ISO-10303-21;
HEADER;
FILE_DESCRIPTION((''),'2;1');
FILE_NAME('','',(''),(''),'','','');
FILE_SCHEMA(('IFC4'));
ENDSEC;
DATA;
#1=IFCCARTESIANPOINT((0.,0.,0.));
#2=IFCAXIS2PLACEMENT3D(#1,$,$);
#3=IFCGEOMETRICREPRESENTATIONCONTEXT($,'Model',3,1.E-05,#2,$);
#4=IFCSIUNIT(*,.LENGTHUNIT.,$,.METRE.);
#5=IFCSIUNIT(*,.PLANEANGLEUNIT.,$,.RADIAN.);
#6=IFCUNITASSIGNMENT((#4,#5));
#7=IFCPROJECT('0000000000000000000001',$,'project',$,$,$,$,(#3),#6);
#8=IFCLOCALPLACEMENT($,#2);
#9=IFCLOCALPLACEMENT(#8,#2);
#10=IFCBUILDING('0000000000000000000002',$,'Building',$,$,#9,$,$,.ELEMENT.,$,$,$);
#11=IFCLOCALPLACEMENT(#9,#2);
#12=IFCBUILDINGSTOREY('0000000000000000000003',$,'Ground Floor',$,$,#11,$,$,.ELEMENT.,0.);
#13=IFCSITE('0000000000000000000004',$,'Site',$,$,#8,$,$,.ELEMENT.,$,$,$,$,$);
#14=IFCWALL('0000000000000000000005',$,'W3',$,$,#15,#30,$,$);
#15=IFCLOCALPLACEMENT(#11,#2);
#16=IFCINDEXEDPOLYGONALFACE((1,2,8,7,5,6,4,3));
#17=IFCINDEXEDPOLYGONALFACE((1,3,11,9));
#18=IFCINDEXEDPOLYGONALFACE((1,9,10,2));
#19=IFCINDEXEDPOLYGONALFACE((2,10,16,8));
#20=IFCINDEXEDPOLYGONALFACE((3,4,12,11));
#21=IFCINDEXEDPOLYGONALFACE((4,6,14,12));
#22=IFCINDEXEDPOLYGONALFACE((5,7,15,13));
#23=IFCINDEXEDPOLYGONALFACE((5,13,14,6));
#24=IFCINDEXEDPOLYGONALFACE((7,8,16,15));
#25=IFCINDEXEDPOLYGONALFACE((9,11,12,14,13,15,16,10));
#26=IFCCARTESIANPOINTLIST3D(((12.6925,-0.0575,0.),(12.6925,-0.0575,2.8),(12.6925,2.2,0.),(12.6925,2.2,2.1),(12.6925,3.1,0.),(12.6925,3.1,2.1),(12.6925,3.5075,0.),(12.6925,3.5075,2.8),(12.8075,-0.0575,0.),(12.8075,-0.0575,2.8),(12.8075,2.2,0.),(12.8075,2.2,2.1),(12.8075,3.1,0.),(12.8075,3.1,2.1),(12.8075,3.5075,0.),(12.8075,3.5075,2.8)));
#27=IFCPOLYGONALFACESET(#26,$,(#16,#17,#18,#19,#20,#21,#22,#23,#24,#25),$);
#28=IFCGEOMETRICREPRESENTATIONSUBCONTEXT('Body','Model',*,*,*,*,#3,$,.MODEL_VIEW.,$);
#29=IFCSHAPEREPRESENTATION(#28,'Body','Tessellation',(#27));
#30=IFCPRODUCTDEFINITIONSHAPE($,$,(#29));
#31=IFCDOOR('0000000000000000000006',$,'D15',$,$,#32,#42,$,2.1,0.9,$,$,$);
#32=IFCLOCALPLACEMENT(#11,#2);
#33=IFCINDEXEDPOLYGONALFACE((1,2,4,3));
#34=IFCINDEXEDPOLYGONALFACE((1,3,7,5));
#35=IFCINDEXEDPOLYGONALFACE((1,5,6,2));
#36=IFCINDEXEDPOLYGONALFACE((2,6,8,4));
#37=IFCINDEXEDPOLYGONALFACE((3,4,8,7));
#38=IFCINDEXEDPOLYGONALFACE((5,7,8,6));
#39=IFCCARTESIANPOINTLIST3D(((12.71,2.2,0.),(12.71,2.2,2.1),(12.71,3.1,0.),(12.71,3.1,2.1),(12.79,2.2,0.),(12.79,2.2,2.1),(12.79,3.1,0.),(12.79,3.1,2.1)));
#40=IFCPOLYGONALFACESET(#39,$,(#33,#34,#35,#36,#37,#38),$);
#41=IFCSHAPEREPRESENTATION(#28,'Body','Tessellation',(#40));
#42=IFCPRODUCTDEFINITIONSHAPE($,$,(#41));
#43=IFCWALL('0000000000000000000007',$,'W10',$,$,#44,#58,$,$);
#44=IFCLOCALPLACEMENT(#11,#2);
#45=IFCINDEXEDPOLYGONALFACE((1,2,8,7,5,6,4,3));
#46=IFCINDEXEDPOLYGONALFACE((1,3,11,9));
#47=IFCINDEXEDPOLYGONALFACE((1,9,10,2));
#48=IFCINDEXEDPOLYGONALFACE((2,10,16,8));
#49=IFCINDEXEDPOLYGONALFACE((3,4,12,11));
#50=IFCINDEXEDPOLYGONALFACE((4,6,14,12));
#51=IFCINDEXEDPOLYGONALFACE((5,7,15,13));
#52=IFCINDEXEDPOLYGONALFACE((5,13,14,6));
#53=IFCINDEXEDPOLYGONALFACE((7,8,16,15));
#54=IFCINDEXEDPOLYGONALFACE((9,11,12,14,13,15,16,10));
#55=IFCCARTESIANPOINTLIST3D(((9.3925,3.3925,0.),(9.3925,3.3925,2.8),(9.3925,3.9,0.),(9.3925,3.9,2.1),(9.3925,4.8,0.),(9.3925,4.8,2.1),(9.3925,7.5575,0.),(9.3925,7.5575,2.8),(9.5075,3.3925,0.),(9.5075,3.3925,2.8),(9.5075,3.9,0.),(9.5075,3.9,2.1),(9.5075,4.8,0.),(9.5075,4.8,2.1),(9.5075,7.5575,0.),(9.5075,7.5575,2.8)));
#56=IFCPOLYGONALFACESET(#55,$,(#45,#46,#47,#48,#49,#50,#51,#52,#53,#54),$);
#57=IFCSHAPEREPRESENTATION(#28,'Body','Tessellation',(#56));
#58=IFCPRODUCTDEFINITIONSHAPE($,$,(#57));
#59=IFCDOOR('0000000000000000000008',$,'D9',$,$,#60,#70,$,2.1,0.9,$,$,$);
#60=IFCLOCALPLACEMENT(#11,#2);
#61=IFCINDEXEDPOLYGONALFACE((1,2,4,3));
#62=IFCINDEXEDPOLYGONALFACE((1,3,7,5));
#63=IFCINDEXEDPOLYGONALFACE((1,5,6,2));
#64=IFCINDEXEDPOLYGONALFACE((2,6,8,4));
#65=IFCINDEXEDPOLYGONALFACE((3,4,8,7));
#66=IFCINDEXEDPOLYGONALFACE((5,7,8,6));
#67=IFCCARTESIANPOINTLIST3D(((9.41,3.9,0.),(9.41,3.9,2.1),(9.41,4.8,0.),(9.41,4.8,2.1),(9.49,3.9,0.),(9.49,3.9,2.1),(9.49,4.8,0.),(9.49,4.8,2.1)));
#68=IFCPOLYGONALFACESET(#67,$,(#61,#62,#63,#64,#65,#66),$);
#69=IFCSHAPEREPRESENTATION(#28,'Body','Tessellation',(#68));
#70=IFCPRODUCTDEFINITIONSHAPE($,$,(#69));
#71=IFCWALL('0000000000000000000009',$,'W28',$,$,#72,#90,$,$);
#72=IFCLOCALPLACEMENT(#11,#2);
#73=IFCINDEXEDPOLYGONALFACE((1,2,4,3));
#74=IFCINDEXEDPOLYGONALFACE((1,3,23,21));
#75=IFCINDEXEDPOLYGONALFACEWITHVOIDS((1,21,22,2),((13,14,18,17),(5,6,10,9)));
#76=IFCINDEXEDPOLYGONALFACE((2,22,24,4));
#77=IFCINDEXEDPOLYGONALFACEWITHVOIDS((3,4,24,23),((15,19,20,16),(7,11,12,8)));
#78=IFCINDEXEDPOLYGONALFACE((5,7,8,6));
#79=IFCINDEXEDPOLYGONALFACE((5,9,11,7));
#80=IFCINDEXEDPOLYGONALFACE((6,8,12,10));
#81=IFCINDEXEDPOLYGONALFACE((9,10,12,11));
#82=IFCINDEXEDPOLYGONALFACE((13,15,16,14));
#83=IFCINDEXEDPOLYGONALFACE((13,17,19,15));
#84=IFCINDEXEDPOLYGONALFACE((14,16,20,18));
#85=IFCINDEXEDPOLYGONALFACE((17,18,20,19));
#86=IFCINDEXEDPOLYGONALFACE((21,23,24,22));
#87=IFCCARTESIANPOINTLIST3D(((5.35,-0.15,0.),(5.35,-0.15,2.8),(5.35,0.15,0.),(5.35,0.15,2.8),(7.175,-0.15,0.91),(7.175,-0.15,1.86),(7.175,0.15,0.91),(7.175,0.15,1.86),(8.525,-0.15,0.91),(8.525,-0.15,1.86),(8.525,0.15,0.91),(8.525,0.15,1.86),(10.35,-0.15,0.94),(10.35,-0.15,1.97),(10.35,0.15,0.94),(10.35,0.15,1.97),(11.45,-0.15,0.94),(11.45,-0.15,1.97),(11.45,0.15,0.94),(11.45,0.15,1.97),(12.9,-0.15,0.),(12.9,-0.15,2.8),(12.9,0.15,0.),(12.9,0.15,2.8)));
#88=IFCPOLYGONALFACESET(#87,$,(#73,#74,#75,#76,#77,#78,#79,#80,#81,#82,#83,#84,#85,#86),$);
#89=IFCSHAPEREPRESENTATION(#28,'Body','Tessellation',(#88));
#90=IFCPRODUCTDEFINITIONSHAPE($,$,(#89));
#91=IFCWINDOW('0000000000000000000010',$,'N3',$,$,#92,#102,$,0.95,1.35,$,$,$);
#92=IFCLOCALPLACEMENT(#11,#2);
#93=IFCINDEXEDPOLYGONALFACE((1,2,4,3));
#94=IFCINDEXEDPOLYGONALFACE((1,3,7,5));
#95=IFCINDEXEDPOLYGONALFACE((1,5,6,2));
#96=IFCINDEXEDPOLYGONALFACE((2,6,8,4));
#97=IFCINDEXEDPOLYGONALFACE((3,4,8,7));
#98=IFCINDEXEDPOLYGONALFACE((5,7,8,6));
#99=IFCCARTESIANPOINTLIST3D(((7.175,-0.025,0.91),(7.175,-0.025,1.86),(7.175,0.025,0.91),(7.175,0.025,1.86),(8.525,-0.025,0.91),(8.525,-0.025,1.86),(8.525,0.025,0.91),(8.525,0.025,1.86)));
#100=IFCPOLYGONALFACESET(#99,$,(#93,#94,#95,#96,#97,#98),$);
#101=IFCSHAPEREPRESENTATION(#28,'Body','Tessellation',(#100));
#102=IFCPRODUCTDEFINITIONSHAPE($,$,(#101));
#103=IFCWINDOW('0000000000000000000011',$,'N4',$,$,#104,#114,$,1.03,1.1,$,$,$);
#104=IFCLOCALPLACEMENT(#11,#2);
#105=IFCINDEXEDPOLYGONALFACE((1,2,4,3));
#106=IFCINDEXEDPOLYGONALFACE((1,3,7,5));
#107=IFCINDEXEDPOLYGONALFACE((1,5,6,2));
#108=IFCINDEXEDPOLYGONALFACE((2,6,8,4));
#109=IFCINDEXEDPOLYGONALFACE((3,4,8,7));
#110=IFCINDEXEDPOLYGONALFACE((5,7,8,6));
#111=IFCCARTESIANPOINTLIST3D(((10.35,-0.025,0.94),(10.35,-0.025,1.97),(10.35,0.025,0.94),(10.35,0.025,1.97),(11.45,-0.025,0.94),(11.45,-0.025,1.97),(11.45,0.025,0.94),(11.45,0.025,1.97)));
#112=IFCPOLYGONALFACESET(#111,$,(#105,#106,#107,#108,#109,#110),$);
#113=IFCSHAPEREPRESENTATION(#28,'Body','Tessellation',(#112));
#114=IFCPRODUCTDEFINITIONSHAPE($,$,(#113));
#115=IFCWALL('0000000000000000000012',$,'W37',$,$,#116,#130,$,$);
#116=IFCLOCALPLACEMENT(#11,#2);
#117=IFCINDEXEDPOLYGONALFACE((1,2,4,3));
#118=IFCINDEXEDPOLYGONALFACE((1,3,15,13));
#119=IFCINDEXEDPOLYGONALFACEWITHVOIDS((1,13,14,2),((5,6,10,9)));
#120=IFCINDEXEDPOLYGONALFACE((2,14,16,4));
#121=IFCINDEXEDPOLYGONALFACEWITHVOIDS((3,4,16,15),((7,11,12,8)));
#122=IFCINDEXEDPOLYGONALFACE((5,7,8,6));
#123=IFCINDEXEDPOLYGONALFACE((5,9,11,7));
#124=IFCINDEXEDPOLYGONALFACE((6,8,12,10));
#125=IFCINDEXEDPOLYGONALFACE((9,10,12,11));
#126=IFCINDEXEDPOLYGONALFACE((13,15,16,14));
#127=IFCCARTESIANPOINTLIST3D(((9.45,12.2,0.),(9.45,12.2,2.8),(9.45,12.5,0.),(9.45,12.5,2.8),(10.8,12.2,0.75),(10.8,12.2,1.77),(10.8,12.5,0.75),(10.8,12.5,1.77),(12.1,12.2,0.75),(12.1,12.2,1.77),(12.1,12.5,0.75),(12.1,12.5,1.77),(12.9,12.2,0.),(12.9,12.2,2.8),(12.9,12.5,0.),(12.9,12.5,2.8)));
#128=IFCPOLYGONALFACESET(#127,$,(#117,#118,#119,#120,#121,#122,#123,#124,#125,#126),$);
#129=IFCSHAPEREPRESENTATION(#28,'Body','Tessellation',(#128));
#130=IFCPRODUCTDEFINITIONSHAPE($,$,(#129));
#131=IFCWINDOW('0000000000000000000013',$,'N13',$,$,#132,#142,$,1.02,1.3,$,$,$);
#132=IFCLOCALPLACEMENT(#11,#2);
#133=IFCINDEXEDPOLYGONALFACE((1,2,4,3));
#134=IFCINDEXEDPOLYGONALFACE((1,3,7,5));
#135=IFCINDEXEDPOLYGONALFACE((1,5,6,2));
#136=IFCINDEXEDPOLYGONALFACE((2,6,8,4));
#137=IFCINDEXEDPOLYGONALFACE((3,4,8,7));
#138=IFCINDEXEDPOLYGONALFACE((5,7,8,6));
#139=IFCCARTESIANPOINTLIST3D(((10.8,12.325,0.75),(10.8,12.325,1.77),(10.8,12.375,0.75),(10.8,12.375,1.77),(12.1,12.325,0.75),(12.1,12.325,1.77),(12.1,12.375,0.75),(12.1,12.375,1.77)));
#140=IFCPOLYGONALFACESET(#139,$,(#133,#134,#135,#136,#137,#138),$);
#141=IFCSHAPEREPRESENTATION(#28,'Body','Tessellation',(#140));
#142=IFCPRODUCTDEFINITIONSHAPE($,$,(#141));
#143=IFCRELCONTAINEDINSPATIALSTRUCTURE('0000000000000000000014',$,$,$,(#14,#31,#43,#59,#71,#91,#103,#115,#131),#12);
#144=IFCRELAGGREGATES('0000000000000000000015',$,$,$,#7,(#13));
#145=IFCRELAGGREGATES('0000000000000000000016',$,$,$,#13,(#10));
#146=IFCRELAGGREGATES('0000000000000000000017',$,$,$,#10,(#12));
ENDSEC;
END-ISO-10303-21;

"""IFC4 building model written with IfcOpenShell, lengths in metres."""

from ifc_helpers import new_model, si_unit, frame, frame_2d, origin, origin_2d, place, context, subcontext, project, spatial, rectangle, extrude, element, fill, save


model = new_model("IFC4")

# Units and contexts
model_context = context("Model", 3, precision=1e-05, world=origin())
body_context = subcontext(model_context, "Body", "Model", "MODEL_VIEW")
ifc_project = project(units=[si_unit("LENGTHUNIT", "METRE"), si_unit("PLANEANGLEUNIT", "RADIAN")], contexts=[model_context])

# Site, building, storey
site_placement = place(None, origin())
site = spatial("IfcSite", under=ifc_project, at=site_placement, Name="Site", CompositionType="ELEMENT")
building_placement = place(site_placement, origin())
building = spatial("IfcBuilding", under=site, at=building_placement, Name="Building", CompositionType="ELEMENT")
storey_placement = place(building_placement, origin())
storey = spatial("IfcBuildingStorey", under=building, at=storey_placement, Name="Ground Floor", CompositionType="ELEMENT", Elevation=0.0)

# Walls, openings, doors
wall_1_placement = place(storey_placement, frame((12.75, 0.0, 0.0), x_axis=(0.0, 1.0, 0.0)))
wall_1 = element("IfcWall", 1, at=wall_1_placement, inside=storey, Name="W3", context=body_context, shape_type="SweptSolid", body=[
    extrude(rectangle(XDim=3.565, YDim=0.115, at=frame_2d((1.725, 0.0))), origin(), (0.0, 0.0, 1.0), 2.8),
])
opening_1_placement = place(wall_1_placement, frame((2.65, 0.0, 0.0)))
opening_1 = element("IfcOpeningElement", 2, at=opening_1_placement, cuts=wall_1, context=body_context, shape_type="SweptSolid", body=[
    extrude(rectangle(XDim=0.9, YDim=0.215, at=origin_2d()), origin(), (0.0, 0.0, 1.0), 2.1),
])
door_1_placement = place(opening_1_placement, origin())
door_1 = element("IfcDoor", 3, at=door_1_placement, inside=storey, Name="D15", OverallHeight=2.1, OverallWidth=0.9, context=body_context, shape_type="SweptSolid", body=[
    extrude(rectangle(XDim=0.9, YDim=0.08, at=origin_2d()), origin(), (0.0, 0.0, 1.0), 2.1),
])
fill(opening_1, door_1)
wall_2_placement = place(storey_placement, frame((9.45, 3.45, 0.0), x_axis=(0.0, 1.0, 0.0)))
wall_2 = element("IfcWall", 4, at=wall_2_placement, inside=storey, Name="W10", context=body_context, shape_type="SweptSolid", body=[
    extrude(rectangle(XDim=4.165, YDim=0.115, at=frame_2d((2.025, 0.0))), origin(), (0.0, 0.0, 1.0), 2.8),
])
opening_2_placement = place(wall_2_placement, frame((0.9, 0.0, 0.0)))
opening_2 = element("IfcOpeningElement", 5, at=opening_2_placement, cuts=wall_2, context=body_context, shape_type="SweptSolid", body=[
    extrude(rectangle(XDim=0.9, YDim=0.215, at=origin_2d()), origin(), (0.0, 0.0, 1.0), 2.1),
])
door_2_placement = place(opening_2_placement, origin())
door_2 = element("IfcDoor", 6, at=door_2_placement, inside=storey, Name="D9", OverallHeight=2.1, OverallWidth=0.9, context=body_context, shape_type="SweptSolid", body=[
    extrude(rectangle(XDim=0.9, YDim=0.08, at=origin_2d()), origin(), (0.0, 0.0, 1.0), 2.1),
])
fill(opening_2, door_2)

# Wall, openings, windows
wall_3_placement = place(storey_placement, frame((5.5, 0.0, 0.0), x_axis=(1.0, 0.0, 0.0)))
wall_3 = element("IfcWall", 7, at=wall_3_placement, inside=storey, Name="W28", context=body_context, shape_type="SweptSolid", body=[
    extrude(rectangle(XDim=7.55, YDim=0.3, at=frame_2d((3.625, 0.0))), origin(), (0.0, 0.0, 1.0), 2.8),
])
opening_3_placement = place(wall_3_placement, frame((2.35, 0.0, 0.91)))
opening_3 = element("IfcOpeningElement", 8, at=opening_3_placement, cuts=wall_3, context=body_context, shape_type="SweptSolid", body=[
    extrude(rectangle(XDim=1.35, YDim=0.4, at=origin_2d()), origin(), (0.0, 0.0, 1.0), 0.95),
])
opening_4_placement = place(wall_3_placement, frame((5.4, 0.0, 0.94)))
opening_4 = element("IfcOpeningElement", 9, at=opening_4_placement, cuts=wall_3, context=body_context, shape_type="SweptSolid", body=[
    extrude(rectangle(XDim=1.1, YDim=0.4, at=origin_2d()), origin(), (0.0, 0.0, 1.0), 1.03),
])
window_1_placement = place(opening_3_placement, origin())
window_1 = element("IfcWindow", 10, at=window_1_placement, inside=storey, Name="N3", OverallHeight=0.95, OverallWidth=1.35, context=body_context, shape_type="SweptSolid", body=[
    extrude(rectangle(XDim=1.35, YDim=0.05, at=origin_2d()), origin(), (0.0, 0.0, 1.0), 0.95),
])
fill(opening_3, window_1)
window_2_placement = place(opening_4_placement, origin())
window_2 = element("IfcWindow", 11, at=window_2_placement, inside=storey, Name="N4", OverallHeight=1.03, OverallWidth=1.1, context=body_context, shape_type="SweptSolid", body=[
    extrude(rectangle(XDim=1.1, YDim=0.05, at=origin_2d()), origin(), (0.0, 0.0, 1.0), 1.03),
])
fill(opening_4, window_2)

# Wall, opening, window
wall_4_placement = place(storey_placement, frame((9.6, 12.35, 0.0), x_axis=(1.0, 0.0, 0.0)))
wall_4 = element("IfcWall", 12, at=wall_4_placement, inside=storey, Name="W37", context=body_context, shape_type="SweptSolid", body=[
    extrude(rectangle(XDim=3.45, YDim=0.3, at=frame_2d((1.575, 0.0))), origin(), (0.0, 0.0, 1.0), 2.8),
])
opening_5_placement = place(wall_4_placement, frame((1.85, 0.0, 0.75)))
opening_5 = element("IfcOpeningElement", 13, at=opening_5_placement, cuts=wall_4, context=body_context, shape_type="SweptSolid", body=[
    extrude(rectangle(XDim=1.3, YDim=0.4, at=origin_2d()), origin(), (0.0, 0.0, 1.0), 1.02),
])
window_3_placement = place(opening_5_placement, origin())
window_3 = element("IfcWindow", 14, at=window_3_placement, inside=storey, Name="N13", OverallHeight=1.02, OverallWidth=1.3, context=body_context, shape_type="SweptSolid", body=[
    extrude(rectangle(XDim=1.3, YDim=0.05, at=origin_2d()), origin(), (0.0, 0.0, 1.0), 1.02),
])
fill(opening_5, window_3)

save(model, "model.ifc")
